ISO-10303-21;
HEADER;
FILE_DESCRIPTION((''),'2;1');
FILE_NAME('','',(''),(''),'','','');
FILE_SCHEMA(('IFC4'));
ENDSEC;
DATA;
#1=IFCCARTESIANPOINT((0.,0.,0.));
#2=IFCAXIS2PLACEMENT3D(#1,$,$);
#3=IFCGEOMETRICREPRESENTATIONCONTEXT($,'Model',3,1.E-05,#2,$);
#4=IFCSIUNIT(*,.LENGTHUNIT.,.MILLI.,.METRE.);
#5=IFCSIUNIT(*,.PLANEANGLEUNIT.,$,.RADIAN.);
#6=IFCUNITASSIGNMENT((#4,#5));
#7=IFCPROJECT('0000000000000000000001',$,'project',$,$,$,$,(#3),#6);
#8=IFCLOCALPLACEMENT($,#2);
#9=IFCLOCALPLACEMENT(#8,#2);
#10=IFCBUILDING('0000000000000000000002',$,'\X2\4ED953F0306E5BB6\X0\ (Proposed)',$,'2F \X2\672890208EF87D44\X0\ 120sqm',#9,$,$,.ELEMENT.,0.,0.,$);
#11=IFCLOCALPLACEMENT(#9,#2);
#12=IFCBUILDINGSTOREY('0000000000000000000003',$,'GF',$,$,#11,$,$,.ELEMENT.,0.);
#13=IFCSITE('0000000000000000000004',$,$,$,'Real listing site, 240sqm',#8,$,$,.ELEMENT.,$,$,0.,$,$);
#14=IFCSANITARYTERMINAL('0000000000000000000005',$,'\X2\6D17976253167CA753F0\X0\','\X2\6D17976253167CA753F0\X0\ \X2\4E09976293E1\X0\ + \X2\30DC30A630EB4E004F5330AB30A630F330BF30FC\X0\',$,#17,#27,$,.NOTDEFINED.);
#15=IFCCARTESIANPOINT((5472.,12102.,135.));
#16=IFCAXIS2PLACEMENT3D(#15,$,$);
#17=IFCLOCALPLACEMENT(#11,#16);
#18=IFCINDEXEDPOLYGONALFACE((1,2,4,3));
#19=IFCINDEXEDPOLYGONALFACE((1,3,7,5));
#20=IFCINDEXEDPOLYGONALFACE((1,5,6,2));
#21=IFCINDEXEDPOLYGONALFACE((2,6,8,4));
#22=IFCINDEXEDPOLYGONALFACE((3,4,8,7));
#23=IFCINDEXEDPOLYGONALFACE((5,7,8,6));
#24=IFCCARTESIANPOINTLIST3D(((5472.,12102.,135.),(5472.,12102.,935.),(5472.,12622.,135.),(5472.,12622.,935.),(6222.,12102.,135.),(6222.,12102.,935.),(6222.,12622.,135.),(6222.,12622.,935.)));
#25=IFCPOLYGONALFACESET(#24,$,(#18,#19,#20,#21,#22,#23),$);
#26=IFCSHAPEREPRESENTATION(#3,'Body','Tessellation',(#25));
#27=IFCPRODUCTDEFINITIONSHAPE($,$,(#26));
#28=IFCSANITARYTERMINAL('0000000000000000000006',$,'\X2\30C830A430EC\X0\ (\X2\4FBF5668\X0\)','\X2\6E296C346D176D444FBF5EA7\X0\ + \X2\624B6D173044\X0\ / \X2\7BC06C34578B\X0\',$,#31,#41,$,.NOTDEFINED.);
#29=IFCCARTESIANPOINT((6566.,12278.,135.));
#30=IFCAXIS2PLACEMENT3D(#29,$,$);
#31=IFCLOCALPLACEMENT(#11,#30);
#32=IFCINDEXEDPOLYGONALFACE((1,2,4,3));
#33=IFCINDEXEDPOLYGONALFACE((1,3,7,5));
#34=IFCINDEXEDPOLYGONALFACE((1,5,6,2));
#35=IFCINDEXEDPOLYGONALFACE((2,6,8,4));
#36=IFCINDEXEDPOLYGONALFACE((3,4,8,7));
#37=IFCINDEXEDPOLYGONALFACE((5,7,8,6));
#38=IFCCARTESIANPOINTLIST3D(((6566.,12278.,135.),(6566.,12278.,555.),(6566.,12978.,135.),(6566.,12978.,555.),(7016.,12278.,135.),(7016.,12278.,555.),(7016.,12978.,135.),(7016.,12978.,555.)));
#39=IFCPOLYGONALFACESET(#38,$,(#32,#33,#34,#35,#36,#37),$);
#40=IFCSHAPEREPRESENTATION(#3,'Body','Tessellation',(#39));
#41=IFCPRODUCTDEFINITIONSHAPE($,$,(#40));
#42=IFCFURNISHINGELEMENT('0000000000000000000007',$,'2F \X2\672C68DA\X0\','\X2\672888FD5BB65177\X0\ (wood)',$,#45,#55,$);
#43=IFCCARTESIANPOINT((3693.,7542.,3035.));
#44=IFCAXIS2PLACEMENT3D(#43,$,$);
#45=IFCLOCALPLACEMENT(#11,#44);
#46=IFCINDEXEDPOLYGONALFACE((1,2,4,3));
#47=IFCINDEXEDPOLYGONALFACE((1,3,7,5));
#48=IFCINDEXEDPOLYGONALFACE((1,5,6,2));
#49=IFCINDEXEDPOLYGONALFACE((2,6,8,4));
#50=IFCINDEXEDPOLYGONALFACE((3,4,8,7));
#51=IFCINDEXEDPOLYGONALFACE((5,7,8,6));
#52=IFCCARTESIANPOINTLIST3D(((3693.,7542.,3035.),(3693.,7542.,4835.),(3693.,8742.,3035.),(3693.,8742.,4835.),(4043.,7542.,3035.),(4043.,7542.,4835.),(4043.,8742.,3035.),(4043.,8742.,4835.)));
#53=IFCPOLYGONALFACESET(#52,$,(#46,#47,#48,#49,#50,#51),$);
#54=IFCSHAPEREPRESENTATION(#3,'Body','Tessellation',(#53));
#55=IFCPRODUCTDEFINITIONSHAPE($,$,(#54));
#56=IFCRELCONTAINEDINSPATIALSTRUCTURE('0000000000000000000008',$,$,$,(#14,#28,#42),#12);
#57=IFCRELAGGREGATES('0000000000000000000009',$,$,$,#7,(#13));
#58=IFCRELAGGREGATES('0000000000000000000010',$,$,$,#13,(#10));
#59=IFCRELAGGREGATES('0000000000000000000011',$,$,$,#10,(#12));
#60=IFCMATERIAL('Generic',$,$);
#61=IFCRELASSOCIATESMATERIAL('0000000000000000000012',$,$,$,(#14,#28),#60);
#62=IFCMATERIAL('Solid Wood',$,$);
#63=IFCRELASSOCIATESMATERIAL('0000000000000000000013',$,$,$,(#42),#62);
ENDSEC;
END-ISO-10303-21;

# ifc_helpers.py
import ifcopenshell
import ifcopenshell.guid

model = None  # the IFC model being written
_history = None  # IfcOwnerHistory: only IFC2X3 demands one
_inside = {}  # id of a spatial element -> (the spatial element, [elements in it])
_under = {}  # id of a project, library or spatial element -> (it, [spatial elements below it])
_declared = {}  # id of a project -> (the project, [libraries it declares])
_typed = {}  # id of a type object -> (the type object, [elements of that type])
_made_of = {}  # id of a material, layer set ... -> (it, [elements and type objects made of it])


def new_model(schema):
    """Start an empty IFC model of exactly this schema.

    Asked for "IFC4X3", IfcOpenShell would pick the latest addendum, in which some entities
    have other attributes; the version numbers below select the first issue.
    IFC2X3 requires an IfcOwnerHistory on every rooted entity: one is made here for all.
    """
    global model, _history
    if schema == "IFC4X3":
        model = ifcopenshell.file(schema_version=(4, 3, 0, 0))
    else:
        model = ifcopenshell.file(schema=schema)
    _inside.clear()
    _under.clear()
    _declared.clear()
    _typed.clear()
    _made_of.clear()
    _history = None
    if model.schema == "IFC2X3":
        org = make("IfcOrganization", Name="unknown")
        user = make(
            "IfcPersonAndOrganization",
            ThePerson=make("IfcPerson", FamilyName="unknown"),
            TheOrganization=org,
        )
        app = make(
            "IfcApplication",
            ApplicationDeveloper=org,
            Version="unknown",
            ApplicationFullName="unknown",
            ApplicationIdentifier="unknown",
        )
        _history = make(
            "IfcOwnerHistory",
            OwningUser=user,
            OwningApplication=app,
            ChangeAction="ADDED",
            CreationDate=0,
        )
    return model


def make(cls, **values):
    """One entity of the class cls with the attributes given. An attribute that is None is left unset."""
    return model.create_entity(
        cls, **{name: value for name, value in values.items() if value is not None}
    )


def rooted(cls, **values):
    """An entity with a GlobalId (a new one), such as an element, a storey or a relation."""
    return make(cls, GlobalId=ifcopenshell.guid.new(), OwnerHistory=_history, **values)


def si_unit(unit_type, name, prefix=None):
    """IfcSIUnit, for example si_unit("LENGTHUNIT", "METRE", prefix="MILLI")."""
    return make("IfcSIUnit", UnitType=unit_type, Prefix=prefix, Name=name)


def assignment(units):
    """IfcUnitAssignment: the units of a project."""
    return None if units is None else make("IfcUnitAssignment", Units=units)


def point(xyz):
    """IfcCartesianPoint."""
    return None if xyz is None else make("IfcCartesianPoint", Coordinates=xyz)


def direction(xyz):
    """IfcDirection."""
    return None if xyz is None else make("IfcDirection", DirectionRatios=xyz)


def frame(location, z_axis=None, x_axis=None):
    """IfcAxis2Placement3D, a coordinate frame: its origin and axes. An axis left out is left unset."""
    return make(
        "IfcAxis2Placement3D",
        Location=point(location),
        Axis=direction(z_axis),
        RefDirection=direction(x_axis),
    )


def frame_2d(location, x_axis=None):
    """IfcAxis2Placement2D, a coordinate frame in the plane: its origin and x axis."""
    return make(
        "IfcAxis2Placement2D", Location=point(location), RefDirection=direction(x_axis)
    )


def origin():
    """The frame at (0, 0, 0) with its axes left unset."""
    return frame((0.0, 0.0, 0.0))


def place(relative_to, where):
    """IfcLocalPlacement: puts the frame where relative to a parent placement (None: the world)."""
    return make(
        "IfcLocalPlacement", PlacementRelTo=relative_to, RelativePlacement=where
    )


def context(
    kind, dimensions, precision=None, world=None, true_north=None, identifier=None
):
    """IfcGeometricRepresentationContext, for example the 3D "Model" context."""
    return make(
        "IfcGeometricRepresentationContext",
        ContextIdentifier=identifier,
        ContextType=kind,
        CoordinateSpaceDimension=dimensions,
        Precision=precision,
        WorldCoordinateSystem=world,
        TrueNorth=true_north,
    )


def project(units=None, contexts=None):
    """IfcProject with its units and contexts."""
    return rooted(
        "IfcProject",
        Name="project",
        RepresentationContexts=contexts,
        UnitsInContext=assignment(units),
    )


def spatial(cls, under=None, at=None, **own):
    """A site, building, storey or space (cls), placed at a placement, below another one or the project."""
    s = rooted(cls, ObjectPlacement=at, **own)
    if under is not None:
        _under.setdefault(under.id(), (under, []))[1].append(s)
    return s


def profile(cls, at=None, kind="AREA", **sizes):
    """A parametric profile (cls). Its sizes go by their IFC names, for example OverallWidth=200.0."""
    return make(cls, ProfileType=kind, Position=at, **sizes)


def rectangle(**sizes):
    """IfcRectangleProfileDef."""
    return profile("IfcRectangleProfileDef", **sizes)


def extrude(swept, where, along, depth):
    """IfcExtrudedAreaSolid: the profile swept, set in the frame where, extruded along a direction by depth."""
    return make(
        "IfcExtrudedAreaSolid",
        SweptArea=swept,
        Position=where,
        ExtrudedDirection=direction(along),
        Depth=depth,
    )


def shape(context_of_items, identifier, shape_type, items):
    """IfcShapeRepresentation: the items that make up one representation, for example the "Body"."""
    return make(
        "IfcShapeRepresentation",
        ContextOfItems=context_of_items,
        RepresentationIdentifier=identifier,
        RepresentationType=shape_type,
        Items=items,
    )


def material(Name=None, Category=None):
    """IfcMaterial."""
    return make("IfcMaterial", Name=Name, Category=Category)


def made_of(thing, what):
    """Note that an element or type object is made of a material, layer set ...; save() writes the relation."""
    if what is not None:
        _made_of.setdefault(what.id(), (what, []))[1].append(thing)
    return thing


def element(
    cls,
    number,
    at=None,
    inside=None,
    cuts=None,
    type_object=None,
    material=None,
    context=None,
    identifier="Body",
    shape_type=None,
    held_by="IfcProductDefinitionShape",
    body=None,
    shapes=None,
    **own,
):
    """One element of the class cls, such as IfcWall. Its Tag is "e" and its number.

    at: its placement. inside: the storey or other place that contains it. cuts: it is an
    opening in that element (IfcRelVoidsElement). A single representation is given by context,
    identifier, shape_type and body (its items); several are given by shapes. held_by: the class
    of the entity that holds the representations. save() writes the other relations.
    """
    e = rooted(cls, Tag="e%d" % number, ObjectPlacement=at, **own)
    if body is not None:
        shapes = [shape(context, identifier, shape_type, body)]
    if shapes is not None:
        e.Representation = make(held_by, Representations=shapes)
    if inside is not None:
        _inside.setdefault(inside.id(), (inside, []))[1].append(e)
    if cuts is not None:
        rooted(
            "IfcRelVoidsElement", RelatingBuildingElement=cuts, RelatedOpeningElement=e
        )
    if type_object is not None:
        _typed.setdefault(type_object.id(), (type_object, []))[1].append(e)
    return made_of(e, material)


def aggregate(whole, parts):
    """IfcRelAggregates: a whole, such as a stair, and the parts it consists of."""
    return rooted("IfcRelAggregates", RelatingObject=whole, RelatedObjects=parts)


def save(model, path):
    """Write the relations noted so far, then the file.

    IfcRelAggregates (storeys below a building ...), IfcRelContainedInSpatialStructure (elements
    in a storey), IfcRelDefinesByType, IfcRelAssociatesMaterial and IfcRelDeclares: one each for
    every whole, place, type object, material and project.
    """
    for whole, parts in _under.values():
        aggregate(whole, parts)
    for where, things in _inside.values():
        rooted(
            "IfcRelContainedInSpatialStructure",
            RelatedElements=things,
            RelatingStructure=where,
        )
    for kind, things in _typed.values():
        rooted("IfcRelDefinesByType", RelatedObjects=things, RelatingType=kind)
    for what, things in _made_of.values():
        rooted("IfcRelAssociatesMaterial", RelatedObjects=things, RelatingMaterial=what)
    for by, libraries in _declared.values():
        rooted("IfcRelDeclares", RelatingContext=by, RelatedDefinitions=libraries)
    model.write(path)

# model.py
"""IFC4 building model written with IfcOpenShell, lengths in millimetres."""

from ifc_helpers import new_model, si_unit, frame, frame_2d, origin, place, context, project, spatial, rectangle, extrude, material, element, save


model = new_model("IFC4")

# Units and contexts
model_context = context("Model", 3, precision=1e-05, world=origin())
ifc_project = project(units=[si_unit("LENGTHUNIT", "METRE", prefix="MILLI"), si_unit("PLANEANGLEUNIT", "RADIAN")], contexts=[model_context])

# Site, building, storey
site_placement = place(None, origin())
site = spatial("IfcSite", under=ifc_project, at=site_placement, ObjectType="Real listing site, 240sqm", CompositionType="ELEMENT", RefElevation=0.0)
building_placement = place(site_placement, origin())
building = spatial("IfcBuilding", under=site, at=building_placement, Name="仙台の家 (Proposed)", ObjectType="2F 木造軸組 120sqm", CompositionType="ELEMENT", ElevationOfRefHeight=0.0, ElevationOfTerrain=0.0)
storey_placement = place(building_placement, origin())
storey = spatial("IfcBuildingStorey", under=building, at=storey_placement, Name="GF", CompositionType="ELEMENT", Elevation=0.0)

# Shared definitions
ifc_material_1 = material(Name="Solid Wood")

# Shared definitions
ifc_material_2 = material(Name="Generic")

# Sanitary terminals
sanitary_terminal_1_placement = place(storey_placement, frame((5472.0, 12102.0, 135.0)))
element("IfcSanitaryTerminal", 1, at=sanitary_terminal_1_placement, inside=storey, material=ifc_material_2, Name="洗面化粧台", Description="洗面化粧台 三面鏡 + ボウル一体カウンター", PredefinedType="NOTDEFINED", context=model_context, shape_type="SweptSolid", body=[
    extrude(rectangle(XDim=750.0, YDim=520.0, at=frame_2d((375.0, 260.0))), frame((5472.0, 12102.0, 135.0)), (0.0, 0.0, 1.0), 800.0),
])
sanitary_terminal_2_placement = place(storey_placement, frame((6566.0, 12278.0, 135.0)))
element("IfcSanitaryTerminal", 2, at=sanitary_terminal_2_placement, inside=storey, material=ifc_material_2, Name="トイレ (便器)", Description="温水洗浄便座 + 手洗い / 節水型", PredefinedType="NOTDEFINED", context=model_context, shape_type="SweptSolid", body=[
    extrude(rectangle(XDim=450.0, YDim=700.0, at=frame_2d((225.0, 350.0))), frame((6566.0, 12278.0, 135.0)), (0.0, 0.0, 1.0), 420.0),
])

# Furnishing element
furnishing_placement = place(storey_placement, frame((3693.0, 7542.0, 3035.0)))
element("IfcFurnishingElement", 3, at=furnishing_placement, inside=storey, material=ifc_material_1, Name="2F 本棚", Description="木製家具 (wood)", context=model_context, shape_type="SweptSolid", body=[
    extrude(rectangle(XDim=350.0, YDim=1200.0, at=frame_2d((175.0, 600.0))), frame((3693.0, 7542.0, 3035.0)), (0.0, 0.0, 1.0), 1800.0),
])

save(model, "model.ifc")
